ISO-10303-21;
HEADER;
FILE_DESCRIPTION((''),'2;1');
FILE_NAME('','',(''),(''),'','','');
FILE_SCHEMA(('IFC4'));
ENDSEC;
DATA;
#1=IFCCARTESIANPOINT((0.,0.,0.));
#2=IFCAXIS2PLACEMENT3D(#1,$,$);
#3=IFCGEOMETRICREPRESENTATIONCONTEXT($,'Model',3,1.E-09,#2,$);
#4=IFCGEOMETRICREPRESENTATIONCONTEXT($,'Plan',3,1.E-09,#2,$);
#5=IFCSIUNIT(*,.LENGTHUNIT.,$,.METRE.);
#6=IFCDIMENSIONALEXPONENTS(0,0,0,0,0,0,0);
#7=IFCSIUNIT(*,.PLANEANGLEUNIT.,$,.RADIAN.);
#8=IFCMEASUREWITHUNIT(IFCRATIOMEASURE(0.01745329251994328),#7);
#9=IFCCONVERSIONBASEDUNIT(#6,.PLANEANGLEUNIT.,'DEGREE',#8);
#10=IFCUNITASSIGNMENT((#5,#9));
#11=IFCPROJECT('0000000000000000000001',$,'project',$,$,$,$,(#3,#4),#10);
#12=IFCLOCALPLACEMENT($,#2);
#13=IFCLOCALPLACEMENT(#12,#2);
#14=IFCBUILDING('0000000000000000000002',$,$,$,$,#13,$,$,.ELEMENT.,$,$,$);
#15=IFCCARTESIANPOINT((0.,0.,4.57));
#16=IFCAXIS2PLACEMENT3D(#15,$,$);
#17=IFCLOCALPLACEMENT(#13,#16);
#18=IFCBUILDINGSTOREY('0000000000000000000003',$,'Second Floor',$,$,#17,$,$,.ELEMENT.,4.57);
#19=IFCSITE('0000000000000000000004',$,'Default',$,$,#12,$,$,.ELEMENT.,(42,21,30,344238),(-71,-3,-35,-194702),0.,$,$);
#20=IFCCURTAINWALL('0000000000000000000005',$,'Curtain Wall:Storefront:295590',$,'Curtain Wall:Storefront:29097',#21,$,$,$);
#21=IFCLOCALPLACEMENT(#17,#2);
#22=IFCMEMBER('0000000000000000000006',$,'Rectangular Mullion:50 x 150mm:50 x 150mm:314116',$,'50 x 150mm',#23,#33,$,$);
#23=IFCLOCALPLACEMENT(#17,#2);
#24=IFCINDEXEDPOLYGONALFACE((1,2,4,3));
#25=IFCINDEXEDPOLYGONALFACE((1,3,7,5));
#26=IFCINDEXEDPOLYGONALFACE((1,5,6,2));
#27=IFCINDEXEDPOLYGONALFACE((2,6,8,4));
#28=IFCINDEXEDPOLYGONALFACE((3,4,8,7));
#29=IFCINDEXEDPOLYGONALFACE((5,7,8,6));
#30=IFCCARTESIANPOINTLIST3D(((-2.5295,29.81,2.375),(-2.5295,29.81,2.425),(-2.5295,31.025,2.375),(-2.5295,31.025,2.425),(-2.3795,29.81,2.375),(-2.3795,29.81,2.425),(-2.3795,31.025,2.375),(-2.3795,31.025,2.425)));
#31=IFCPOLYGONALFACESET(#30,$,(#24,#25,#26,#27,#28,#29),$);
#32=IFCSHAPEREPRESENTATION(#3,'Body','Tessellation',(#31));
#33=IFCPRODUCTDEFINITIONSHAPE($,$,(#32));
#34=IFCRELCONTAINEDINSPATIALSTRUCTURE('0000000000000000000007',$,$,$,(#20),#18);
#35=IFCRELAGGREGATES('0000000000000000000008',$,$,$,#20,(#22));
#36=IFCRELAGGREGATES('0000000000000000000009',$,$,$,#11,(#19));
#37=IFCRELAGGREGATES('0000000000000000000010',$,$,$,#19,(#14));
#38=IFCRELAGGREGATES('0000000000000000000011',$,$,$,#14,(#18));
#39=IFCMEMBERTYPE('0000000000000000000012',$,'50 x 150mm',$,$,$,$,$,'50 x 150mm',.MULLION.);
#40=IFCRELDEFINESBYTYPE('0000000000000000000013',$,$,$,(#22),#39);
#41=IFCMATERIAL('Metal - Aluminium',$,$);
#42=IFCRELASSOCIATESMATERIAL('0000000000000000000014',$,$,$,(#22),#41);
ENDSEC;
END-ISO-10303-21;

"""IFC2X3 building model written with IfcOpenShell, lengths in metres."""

from ifc_helpers import new_model, entity, si_unit, converted_unit, frame, origin, origin_2d_with_axis, place, context, project, spatial, rectangle, extrude, source, transform, mapped, material, type_object, type_shapes, element, aggregate, save


model = new_model("IFC2X3")

# Units and contexts
model_context = context("Model", 3, precision=1e-09, world=origin())
plan_context = context("Plan", 3, precision=1e-09, world=origin())
ifc_project = project(units=[si_unit("LENGTHUNIT", "METRE"), converted_unit("PLANEANGLEUNIT", "DEGREE", entity("IfcRatioMeasure", 0.01745329251994328), si_unit("PLANEANGLEUNIT", "RADIAN"), dimensions=[0, 0, 0, 0, 0, 0, 0])], contexts=[model_context, plan_context])

# Site, building, storey
site_placement = place(None, origin())
site = spatial("IfcSite", under=ifc_project, at=site_placement, Name="Default", CompositionType="ELEMENT", RefLatitude=(42, 21, 30, 344238), RefLongitude=(-71, -3, -35, -194702), RefElevation=0.0)
building_placement = place(site_placement, origin())
building = spatial("IfcBuilding", under=site, at=building_placement, CompositionType="ELEMENT")
storey_placement = place(building_placement, frame((0.0, 0.0, 4.57)))
storey = spatial("IfcBuildingStorey", under=building, at=storey_placement, Name="Second Floor", CompositionType="ELEMENT", Elevation=4.57)

# Curtain wall, member
curtain_wall_placement = place(storey_placement, origin())
curtain_wall = element("IfcCurtainWall", 1, at=curtain_wall_placement, inside=storey, Name="Curtain Wall:Storefront:295590", ObjectType="Curtain Wall:Storefront:29097")
ifc_material_1 = material(Name="Metal - Aluminium")
member_type_1 = type_object("IfcMemberType", Name="50 x 150mm", ElementType="50 x 150mm", PredefinedType="MULLION")
shared_shape_1 = source(origin(), model_context, "Body", "SweptSolid", [
    extrude(rectangle(XDim=0.05, YDim=0.15, at=origin_2d_with_axis()), frame((0.0, 0.0, -1.215), z_axis=(0.0, 0.0, 1.0), x_axis=(-1.0, 0.0, 0.0)), (0.0, 0.0, 1.0), 1.215),
])
type_shapes(member_type_1, [shared_shape_1])
member_1_placement = place(storey_placement, frame((-2.4545, 29.81, 2.4), z_axis=(0.0, -1.0, 0.0), x_axis=(0.0, 0.0, 1.0)))
member_1 = element("IfcMember", 2, at=member_1_placement, type_object=member_type_1, material=ifc_material_1, Name="Rectangular Mullion:50 x 150mm:50 x 150mm:314116", ObjectType="50 x 150mm", context=model_context, shape_type="MappedRepresentation", body=[
    mapped(shared_shape_1, transform((0.0, 0.0, 0.0), scale=1.0)),
])
aggregate(curtain_wall, [member_1])

save(model, "model.ifc")
